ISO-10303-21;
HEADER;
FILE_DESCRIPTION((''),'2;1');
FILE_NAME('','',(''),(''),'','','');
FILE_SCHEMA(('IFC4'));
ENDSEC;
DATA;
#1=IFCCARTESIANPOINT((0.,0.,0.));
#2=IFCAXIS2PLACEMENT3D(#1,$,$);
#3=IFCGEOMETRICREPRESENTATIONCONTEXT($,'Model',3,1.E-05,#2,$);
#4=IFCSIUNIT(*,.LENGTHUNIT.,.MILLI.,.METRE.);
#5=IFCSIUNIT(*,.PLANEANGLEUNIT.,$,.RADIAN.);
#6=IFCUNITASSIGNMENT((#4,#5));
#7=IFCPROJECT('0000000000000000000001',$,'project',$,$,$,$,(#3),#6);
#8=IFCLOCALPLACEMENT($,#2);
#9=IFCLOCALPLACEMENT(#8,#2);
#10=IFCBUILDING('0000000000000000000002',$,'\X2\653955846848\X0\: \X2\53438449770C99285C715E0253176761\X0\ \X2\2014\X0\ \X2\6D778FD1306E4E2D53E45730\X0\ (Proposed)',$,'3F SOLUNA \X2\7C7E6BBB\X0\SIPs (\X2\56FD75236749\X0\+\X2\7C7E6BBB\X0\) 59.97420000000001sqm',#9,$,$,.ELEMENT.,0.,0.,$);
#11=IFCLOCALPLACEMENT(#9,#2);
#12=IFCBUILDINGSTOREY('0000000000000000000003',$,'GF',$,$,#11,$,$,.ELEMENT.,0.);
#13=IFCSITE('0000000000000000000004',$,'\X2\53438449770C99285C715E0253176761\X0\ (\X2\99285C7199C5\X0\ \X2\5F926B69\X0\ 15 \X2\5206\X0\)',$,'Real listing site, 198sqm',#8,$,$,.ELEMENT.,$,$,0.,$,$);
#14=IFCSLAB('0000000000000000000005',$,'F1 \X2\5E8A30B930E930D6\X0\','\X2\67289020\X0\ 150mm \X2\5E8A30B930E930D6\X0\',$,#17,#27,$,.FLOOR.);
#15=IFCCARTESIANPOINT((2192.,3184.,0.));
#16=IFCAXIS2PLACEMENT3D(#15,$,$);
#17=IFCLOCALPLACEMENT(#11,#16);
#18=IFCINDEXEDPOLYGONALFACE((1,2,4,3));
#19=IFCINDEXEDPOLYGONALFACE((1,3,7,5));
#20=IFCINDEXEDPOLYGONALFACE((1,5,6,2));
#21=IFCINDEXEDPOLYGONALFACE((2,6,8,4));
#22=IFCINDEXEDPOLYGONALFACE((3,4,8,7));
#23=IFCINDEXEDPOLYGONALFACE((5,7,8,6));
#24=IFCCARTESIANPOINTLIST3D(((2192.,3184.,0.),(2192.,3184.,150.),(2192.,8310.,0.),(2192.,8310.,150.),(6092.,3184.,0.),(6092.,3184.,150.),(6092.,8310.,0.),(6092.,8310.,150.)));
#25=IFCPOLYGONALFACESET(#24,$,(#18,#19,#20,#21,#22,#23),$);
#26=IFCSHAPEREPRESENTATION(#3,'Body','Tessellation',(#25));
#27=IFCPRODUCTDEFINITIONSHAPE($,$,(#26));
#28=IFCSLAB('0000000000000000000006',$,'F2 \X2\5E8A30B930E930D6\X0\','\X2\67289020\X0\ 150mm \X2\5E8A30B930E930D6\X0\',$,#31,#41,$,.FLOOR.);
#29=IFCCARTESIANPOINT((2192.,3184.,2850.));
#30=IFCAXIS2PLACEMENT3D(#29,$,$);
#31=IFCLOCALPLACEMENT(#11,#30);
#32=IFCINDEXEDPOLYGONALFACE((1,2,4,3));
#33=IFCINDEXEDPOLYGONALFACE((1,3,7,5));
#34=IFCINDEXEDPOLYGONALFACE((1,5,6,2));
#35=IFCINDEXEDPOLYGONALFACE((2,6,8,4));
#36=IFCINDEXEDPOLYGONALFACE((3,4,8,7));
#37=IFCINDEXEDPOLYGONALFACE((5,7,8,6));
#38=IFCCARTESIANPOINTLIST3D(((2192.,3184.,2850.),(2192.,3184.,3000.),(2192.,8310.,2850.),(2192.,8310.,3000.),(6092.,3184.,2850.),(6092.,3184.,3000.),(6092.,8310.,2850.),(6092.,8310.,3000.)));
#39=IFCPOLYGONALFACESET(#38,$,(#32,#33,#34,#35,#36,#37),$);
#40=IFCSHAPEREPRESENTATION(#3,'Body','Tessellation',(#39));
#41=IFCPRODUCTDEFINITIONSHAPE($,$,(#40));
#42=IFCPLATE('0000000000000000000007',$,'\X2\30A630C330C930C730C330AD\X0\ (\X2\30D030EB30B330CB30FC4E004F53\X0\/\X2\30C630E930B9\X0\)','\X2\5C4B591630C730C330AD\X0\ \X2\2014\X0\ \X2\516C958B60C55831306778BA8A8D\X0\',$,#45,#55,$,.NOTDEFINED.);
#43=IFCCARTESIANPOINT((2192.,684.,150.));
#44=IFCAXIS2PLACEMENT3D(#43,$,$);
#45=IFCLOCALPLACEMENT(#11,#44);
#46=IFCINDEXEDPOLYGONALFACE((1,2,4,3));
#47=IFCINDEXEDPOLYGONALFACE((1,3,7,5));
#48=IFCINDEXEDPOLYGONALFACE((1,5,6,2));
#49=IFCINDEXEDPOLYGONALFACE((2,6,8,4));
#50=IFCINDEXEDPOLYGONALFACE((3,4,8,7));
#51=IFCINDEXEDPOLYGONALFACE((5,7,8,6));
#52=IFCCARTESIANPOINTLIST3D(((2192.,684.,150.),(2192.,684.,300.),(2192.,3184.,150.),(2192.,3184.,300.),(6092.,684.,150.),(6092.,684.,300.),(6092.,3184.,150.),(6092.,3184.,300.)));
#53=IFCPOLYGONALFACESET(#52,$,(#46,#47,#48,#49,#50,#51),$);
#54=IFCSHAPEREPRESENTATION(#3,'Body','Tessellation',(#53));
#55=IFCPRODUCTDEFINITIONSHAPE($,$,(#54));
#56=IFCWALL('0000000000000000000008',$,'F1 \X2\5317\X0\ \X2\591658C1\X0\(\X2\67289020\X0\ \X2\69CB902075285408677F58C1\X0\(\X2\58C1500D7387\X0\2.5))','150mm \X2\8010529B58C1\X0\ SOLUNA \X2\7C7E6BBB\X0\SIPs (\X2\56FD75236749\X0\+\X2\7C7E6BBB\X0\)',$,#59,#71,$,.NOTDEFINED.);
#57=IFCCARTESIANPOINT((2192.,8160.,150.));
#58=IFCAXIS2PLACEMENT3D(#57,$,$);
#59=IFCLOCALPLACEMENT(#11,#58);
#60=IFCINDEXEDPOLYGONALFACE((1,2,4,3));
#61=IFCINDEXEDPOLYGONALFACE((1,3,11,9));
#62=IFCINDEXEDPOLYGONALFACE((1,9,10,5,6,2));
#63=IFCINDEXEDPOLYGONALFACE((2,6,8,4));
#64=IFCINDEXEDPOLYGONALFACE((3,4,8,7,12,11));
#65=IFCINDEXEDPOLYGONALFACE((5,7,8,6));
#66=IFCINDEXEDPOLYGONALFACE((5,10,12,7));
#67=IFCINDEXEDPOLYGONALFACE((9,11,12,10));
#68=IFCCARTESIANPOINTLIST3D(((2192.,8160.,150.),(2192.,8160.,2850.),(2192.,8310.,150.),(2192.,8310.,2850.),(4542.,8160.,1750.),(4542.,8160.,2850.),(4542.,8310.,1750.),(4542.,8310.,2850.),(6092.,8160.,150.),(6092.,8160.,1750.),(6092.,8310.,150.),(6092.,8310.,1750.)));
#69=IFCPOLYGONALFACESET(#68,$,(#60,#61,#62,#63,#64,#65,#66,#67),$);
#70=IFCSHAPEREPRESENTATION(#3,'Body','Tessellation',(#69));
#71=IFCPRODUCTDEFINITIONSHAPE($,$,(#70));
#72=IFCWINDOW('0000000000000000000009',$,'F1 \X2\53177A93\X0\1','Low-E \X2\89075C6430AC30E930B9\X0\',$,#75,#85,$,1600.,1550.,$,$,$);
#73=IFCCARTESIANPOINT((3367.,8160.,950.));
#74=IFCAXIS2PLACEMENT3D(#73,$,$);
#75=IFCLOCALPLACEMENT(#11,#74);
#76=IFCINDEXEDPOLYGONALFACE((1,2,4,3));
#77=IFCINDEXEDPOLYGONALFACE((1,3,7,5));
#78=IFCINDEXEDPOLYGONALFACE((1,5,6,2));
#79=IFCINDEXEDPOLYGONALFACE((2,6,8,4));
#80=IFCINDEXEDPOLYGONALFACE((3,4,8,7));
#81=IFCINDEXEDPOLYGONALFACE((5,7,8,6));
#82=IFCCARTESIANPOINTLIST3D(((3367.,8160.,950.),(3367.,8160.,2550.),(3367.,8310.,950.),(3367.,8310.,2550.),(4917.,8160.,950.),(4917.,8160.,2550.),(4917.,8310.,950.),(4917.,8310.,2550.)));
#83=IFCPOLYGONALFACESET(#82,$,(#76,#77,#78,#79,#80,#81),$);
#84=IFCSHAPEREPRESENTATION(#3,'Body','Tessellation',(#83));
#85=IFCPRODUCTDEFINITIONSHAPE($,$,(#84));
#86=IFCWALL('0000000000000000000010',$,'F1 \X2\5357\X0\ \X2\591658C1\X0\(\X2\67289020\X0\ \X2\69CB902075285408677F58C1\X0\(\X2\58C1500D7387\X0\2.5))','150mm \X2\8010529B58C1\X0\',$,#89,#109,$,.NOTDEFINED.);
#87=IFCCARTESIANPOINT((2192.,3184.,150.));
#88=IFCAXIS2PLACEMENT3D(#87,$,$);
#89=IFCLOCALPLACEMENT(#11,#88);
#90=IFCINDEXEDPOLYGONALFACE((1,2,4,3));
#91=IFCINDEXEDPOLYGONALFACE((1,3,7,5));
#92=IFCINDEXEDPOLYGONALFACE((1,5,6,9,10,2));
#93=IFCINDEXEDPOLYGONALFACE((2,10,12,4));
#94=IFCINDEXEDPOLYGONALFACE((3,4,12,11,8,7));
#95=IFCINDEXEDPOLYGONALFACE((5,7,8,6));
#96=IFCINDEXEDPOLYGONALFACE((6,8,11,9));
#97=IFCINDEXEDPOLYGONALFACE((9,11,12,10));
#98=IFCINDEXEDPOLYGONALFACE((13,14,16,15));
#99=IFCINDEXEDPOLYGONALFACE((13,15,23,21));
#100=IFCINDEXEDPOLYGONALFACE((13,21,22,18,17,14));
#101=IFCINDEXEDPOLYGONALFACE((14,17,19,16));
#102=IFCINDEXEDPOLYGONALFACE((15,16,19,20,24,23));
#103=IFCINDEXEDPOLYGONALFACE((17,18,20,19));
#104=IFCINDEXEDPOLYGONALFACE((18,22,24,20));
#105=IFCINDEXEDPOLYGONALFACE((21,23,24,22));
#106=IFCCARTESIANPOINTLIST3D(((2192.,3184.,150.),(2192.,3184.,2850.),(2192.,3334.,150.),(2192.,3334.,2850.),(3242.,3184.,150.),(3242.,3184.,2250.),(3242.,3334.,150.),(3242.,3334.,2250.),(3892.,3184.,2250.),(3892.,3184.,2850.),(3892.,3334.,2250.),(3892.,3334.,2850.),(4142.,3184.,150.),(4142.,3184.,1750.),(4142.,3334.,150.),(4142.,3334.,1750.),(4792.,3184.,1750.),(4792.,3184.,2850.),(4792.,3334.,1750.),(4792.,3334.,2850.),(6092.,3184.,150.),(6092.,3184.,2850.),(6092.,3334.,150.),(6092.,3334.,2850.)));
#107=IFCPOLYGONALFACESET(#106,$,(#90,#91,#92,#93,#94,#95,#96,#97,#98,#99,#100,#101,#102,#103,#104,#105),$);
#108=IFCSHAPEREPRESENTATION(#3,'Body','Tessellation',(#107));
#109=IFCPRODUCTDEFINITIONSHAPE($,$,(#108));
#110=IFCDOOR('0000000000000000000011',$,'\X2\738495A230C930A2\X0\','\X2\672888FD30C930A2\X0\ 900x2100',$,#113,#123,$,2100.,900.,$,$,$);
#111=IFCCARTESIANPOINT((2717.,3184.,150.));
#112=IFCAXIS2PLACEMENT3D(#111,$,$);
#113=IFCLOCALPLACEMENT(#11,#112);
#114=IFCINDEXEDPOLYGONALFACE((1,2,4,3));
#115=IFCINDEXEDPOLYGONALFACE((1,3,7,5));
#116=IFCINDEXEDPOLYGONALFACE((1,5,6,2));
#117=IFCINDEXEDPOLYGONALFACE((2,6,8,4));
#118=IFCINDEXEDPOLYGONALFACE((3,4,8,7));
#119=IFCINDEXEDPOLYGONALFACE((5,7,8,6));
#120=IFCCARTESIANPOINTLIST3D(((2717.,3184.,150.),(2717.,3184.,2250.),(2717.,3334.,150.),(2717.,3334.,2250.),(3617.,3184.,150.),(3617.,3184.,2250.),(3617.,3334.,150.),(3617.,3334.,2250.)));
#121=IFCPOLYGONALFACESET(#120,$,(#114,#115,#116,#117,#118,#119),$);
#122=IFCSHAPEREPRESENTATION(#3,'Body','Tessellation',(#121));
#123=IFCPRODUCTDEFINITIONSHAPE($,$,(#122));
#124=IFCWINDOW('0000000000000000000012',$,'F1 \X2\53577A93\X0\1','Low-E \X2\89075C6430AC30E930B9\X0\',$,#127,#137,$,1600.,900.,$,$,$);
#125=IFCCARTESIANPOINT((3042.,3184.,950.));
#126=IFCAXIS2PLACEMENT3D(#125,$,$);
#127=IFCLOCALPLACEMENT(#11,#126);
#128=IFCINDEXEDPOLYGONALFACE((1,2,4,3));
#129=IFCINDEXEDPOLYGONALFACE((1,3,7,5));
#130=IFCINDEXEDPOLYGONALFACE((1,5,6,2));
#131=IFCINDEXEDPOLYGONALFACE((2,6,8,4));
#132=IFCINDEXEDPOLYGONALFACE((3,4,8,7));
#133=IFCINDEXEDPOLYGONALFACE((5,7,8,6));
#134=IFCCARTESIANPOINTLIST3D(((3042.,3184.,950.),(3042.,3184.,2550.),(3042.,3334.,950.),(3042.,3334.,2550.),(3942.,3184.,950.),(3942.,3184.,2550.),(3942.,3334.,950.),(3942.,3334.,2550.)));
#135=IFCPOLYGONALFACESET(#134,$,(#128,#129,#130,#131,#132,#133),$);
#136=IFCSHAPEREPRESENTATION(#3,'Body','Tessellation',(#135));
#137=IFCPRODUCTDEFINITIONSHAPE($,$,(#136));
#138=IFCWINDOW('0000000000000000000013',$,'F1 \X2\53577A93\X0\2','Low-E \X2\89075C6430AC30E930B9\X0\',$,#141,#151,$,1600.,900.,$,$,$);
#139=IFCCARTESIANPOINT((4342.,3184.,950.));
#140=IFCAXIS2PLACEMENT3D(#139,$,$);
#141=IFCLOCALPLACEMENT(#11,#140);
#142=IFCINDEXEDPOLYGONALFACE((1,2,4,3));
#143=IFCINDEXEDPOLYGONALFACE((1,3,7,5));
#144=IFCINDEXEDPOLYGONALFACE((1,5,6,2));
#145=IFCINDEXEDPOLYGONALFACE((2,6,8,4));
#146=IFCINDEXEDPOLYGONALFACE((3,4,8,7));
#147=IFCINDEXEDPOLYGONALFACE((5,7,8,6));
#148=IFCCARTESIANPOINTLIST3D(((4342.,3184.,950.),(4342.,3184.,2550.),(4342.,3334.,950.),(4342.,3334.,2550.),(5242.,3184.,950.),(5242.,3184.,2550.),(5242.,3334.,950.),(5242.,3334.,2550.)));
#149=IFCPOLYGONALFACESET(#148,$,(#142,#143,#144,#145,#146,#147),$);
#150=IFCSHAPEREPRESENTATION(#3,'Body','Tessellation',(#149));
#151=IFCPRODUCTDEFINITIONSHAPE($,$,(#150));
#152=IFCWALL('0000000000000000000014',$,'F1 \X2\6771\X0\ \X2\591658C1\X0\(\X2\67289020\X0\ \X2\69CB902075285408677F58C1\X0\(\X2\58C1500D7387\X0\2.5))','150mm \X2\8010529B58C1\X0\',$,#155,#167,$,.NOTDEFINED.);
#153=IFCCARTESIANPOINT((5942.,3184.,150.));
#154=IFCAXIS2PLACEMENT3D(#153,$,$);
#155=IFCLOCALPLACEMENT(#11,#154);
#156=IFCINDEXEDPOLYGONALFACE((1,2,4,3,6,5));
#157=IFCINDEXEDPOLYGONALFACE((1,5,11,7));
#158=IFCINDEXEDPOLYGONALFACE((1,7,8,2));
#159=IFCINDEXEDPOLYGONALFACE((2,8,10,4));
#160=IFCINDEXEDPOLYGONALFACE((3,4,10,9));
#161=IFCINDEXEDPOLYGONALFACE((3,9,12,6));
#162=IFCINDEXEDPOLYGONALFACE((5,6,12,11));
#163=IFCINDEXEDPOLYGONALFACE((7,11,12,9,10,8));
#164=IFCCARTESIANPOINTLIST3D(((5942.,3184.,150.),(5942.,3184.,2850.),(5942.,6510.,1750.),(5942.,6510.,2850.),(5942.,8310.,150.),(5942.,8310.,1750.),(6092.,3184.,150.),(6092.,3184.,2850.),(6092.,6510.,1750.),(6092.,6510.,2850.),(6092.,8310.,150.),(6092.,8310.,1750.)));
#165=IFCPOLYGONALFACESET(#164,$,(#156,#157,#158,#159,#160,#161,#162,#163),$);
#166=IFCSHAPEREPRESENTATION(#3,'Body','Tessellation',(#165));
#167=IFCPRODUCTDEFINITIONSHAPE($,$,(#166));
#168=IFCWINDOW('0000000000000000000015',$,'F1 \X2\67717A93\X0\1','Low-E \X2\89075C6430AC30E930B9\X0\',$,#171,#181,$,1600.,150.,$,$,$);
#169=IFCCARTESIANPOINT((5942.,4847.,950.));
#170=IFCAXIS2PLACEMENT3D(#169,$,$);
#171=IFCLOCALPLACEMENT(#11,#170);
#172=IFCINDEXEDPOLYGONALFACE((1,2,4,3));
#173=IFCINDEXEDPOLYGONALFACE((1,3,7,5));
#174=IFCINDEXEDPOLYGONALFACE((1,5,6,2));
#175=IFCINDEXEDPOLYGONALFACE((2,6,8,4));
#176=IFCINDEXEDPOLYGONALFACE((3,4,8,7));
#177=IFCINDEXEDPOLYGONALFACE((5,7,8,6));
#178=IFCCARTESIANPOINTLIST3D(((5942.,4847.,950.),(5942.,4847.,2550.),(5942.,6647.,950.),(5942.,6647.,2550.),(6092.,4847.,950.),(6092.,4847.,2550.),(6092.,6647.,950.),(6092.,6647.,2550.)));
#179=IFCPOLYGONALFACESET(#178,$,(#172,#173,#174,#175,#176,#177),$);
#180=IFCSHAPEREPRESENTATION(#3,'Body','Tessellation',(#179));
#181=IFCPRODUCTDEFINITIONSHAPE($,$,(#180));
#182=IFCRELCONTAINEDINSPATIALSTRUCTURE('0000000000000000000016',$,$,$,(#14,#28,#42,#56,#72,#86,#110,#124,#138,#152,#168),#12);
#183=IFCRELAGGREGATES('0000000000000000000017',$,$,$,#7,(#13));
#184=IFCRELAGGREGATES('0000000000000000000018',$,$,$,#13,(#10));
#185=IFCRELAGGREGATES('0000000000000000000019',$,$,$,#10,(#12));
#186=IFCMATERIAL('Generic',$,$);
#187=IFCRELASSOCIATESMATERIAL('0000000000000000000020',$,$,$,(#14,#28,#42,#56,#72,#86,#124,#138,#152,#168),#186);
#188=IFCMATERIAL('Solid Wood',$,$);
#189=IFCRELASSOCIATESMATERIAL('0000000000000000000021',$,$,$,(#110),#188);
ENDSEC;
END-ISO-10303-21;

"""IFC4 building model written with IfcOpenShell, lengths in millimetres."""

from ifc_helpers import new_model, si_unit, frame, frame_2d, origin, place, context, project, spatial, rectangle, extrude, material, element, fill, save


model = new_model("IFC4")

# Units and contexts
model_context = context("Model", 3, precision=1e-05, world=origin())
ifc_project = project(units=[si_unit("LENGTHUNIT", "METRE", prefix="MILLI"), si_unit("PLANEANGLEUNIT", "RADIAN")], contexts=[model_context])

# Site, building, storey
site_placement = place(None, origin())
site = spatial("IfcSite", under=ifc_project, at=site_placement, Name="千葉県館山市北条 (館山駅 徒歩 15 分)", ObjectType="Real listing site, 198sqm", CompositionType="ELEMENT", RefElevation=0.0)
building_placement = place(site_placement, origin())
building = spatial("IfcBuilding", under=site, at=building_placement, Name="改善案: 千葉県館山市北条 — 海近の中古地 (Proposed)", ObjectType="3F SOLUNA 籾殻SIPs (国産杉+籾殻) 59.97420000000001sqm", CompositionType="ELEMENT", ElevationOfRefHeight=0.0, ElevationOfTerrain=0.0)
storey_placement = place(building_placement, origin())
storey = spatial("IfcBuildingStorey", under=building, at=storey_placement, Name="GF", CompositionType="ELEMENT", Elevation=0.0)

# Slabs
ifc_material_1 = material(Name="Generic")
slab_1_placement = place(storey_placement, frame((2192.0, 3184.0, 0.0)))
element("IfcSlab", 1, at=slab_1_placement, inside=storey, material=ifc_material_1, Name="F1 床スラブ", Description="木造 150mm 床スラブ", PredefinedType="FLOOR", context=model_context, shape_type="SweptSolid", body=[
    extrude(rectangle(XDim=3900.0, YDim=5126.0, at=frame_2d((1950.0, 2563.0))), frame((2192.0, 3184.0, 0.0)), (0.0, 0.0, 1.0), 150.0),
])
slab_2_placement = place(storey_placement, frame((2192.0, 3184.0, 2850.0)))
element("IfcSlab", 2, at=slab_2_placement, inside=storey, material=ifc_material_1, Name="F2 床スラブ", Description="木造 150mm 床スラブ", PredefinedType="FLOOR", context=model_context, shape_type="SweptSolid", body=[
    extrude(rectangle(XDim=3900.0, YDim=5126.0, at=frame_2d((1950.0, 2563.0))), frame((2192.0, 3184.0, 2850.0)), (0.0, 0.0, 1.0), 150.0),
])

# Plate
plate_placement = place(storey_placement, frame((2192.0, 684.0, 150.0)))
element("IfcPlate", 3, at=plate_placement, inside=storey, material=ifc_material_1, Name="ウッドデッキ (バルコニー一体/テラス)", Description="屋外デッキ — 公開情報で確認", PredefinedType="NOTDEFINED", context=model_context, shape_type="SweptSolid", body=[
    extrude(rectangle(XDim=3900.0, YDim=2500.0, at=frame_2d((1950.0, 1250.0))), frame((2192.0, 684.0, 150.0)), (0.0, 0.0, 1.0), 150.0),
])

# Wall, opening, window
wall_1_placement = place(storey_placement, frame((2192.0, 8160.0, 150.0)))
wall_1 = element("IfcWall", 4, at=wall_1_placement, inside=storey, material=ifc_material_1, Name="F1 北 外壁(木造 構造用合板壁(壁倍率2.5))", Description="150mm 耐力壁 SOLUNA 籾殻SIPs (国産杉+籾殻)", PredefinedType="NOTDEFINED", context=model_context, shape_type="SweptSolid", body=[
    extrude(rectangle(XDim=3900.0, YDim=150.0, at=frame_2d((1950.0, 75.0))), frame((2192.0, 8160.0, 150.0)), (0.0, 0.0, 1.0), 2700.0),
])
opening_1_placement = place(storey_placement, frame((3367.0, 8160.0, 950.0)))
opening_1 = element("IfcOpeningElement", 5, at=opening_1_placement, cuts=wall_1, PredefinedType="NOTDEFINED", context=model_context, shape_type="SweptSolid", body=[
    extrude(rectangle(XDim=1550.0, YDim=150.0, at=frame_2d((775.0, 75.0))), frame((3367.0, 8160.0, 950.0)), (0.0, 0.0, 1.0), 1600.0),
])
window_1_placement = place(storey_placement, frame((3367.0, 8160.0, 950.0)))
window_1 = element("IfcWindow", 6, at=window_1_placement, inside=storey, material=ifc_material_1, Name="F1 北窓1", Description="Low-E 複層ガラス", OverallHeight=1600.0, OverallWidth=1550.0, context=model_context, shape_type="SweptSolid", body=[
    extrude(rectangle(XDim=1550.0, YDim=150.0, at=frame_2d((775.0, 75.0))), frame((3367.0, 8160.0, 950.0)), (0.0, 0.0, 1.0), 1600.0),
])
fill(opening_1, window_1)

# Wall, openings, door, windows
wall_2_placement = place(storey_placement, frame((2192.0, 3184.0, 150.0)))
wall_2 = element("IfcWall", 7, at=wall_2_placement, inside=storey, material=ifc_material_1, Name="F1 南 外壁(木造 構造用合板壁(壁倍率2.5))", Description="150mm 耐力壁", PredefinedType="NOTDEFINED", context=model_context, shape_type="SweptSolid", body=[
    extrude(rectangle(XDim=3900.0, YDim=150.0, at=frame_2d((1950.0, 75.0))), frame((2192.0, 3184.0, 150.0)), (0.0, 0.0, 1.0), 2700.0),
])
opening_2_placement = place(storey_placement, frame((2717.0, 3184.0, 150.0)))
opening_2 = element("IfcOpeningElement", 8, at=opening_2_placement, cuts=wall_2, PredefinedType="NOTDEFINED", context=model_context, shape_type="SweptSolid", body=[
    extrude(rectangle(XDim=900.0, YDim=150.0, at=frame_2d((450.0, 75.0))), frame((2717.0, 3184.0, 150.0)), (0.0, 0.0, 1.0), 2100.0),
])
opening_3_placement = place(storey_placement, frame((3042.0, 3184.0, 950.0)))
opening_3 = element("IfcOpeningElement", 9, at=opening_3_placement, cuts=wall_2, PredefinedType="NOTDEFINED", context=model_context, shape_type="SweptSolid", body=[
    extrude(rectangle(XDim=900.0, YDim=150.0, at=frame_2d((450.0, 75.0))), frame((3042.0, 3184.0, 950.0)), (0.0, 0.0, 1.0), 1600.0),
])
opening_4_placement = place(storey_placement, frame((4342.0, 3184.0, 950.0)))
opening_4 = element("IfcOpeningElement", 10, at=opening_4_placement, cuts=wall_2, PredefinedType="NOTDEFINED", context=model_context, shape_type="SweptSolid", body=[
    extrude(rectangle(XDim=900.0, YDim=150.0, at=frame_2d((450.0, 75.0))), frame((4342.0, 3184.0, 950.0)), (0.0, 0.0, 1.0), 1600.0),
])
ifc_material_2 = material(Name="Solid Wood")
door_placement = place(storey_placement, frame((2717.0, 3184.0, 150.0)))
door = element("IfcDoor", 11, at=door_placement, inside=storey, material=ifc_material_2, Name="玄関ドア", Description="木製ドア 900x2100", OverallHeight=2100.0, OverallWidth=900.0, context=model_context, shape_type="SweptSolid", body=[
    extrude(rectangle(XDim=900.0, YDim=150.0, at=frame_2d((450.0, 75.0))), frame((2717.0, 3184.0, 150.0)), (0.0, 0.0, 1.0), 2100.0),
])
fill(opening_2, door)
window_2_placement = place(storey_placement, frame((3042.0, 3184.0, 950.0)))
window_2 = element("IfcWindow", 12, at=window_2_placement, inside=storey, material=ifc_material_1, Name="F1 南窓1", Description="Low-E 複層ガラス", OverallHeight=1600.0, OverallWidth=900.0, context=model_context, shape_type="SweptSolid", body=[
    extrude(rectangle(XDim=900.0, YDim=150.0, at=frame_2d((450.0, 75.0))), frame((3042.0, 3184.0, 950.0)), (0.0, 0.0, 1.0), 1600.0),
])
fill(opening_3, window_2)
window_3_placement = place(storey_placement, frame((4342.0, 3184.0, 950.0)))
window_3 = element("IfcWindow", 13, at=window_3_placement, inside=storey, material=ifc_material_1, Name="F1 南窓2", Description="Low-E 複層ガラス", OverallHeight=1600.0, OverallWidth=900.0, context=model_context, shape_type="SweptSolid", body=[
    extrude(rectangle(XDim=900.0, YDim=150.0, at=frame_2d((450.0, 75.0))), frame((4342.0, 3184.0, 950.0)), (0.0, 0.0, 1.0), 1600.0),
])
fill(opening_4, window_3)

# Wall, opening, window
wall_3_placement = place(storey_placement, frame((5942.0, 3184.0, 150.0)))
wall_3 = element("IfcWall", 14, at=wall_3_placement, inside=storey, material=ifc_material_1, Name="F1 東 外壁(木造 構造用合板壁(壁倍率2.5))", Description="150mm 耐力壁", PredefinedType="NOTDEFINED", context=model_context, shape_type="SweptSolid", body=[
    extrude(rectangle(XDim=150.0, YDim=5126.0, at=frame_2d((75.0, 2563.0))), frame((5942.0, 3184.0, 150.0)), (0.0, 0.0, 1.0), 2700.0),
])
opening_5_placement = place(storey_placement, frame((5942.0, 4847.0, 950.0)))
opening_5 = element("IfcOpeningElement", 15, at=opening_5_placement, cuts=wall_3, PredefinedType="NOTDEFINED", context=model_context, shape_type="SweptSolid", body=[
    extrude(rectangle(XDim=150.0, YDim=1800.0, at=frame_2d((75.0, 900.0))), frame((5942.0, 4847.0, 950.0)), (0.0, 0.0, 1.0), 1600.0),
])
window_4_placement = place(storey_placement, frame((5942.0, 4847.0, 950.0)))
window_4 = element("IfcWindow", 16, at=window_4_placement, inside=storey, material=ifc_material_1, Name="F1 東窓1", Description="Low-E 複層ガラス", OverallHeight=1600.0, OverallWidth=150.0, context=model_context, shape_type="SweptSolid", body=[
    extrude(rectangle(XDim=150.0, YDim=1800.0, at=frame_2d((75.0, 900.0))), frame((5942.0, 4847.0, 950.0)), (0.0, 0.0, 1.0), 1600.0),
])
fill(opening_5, window_4)

save(model, "model.ifc")
